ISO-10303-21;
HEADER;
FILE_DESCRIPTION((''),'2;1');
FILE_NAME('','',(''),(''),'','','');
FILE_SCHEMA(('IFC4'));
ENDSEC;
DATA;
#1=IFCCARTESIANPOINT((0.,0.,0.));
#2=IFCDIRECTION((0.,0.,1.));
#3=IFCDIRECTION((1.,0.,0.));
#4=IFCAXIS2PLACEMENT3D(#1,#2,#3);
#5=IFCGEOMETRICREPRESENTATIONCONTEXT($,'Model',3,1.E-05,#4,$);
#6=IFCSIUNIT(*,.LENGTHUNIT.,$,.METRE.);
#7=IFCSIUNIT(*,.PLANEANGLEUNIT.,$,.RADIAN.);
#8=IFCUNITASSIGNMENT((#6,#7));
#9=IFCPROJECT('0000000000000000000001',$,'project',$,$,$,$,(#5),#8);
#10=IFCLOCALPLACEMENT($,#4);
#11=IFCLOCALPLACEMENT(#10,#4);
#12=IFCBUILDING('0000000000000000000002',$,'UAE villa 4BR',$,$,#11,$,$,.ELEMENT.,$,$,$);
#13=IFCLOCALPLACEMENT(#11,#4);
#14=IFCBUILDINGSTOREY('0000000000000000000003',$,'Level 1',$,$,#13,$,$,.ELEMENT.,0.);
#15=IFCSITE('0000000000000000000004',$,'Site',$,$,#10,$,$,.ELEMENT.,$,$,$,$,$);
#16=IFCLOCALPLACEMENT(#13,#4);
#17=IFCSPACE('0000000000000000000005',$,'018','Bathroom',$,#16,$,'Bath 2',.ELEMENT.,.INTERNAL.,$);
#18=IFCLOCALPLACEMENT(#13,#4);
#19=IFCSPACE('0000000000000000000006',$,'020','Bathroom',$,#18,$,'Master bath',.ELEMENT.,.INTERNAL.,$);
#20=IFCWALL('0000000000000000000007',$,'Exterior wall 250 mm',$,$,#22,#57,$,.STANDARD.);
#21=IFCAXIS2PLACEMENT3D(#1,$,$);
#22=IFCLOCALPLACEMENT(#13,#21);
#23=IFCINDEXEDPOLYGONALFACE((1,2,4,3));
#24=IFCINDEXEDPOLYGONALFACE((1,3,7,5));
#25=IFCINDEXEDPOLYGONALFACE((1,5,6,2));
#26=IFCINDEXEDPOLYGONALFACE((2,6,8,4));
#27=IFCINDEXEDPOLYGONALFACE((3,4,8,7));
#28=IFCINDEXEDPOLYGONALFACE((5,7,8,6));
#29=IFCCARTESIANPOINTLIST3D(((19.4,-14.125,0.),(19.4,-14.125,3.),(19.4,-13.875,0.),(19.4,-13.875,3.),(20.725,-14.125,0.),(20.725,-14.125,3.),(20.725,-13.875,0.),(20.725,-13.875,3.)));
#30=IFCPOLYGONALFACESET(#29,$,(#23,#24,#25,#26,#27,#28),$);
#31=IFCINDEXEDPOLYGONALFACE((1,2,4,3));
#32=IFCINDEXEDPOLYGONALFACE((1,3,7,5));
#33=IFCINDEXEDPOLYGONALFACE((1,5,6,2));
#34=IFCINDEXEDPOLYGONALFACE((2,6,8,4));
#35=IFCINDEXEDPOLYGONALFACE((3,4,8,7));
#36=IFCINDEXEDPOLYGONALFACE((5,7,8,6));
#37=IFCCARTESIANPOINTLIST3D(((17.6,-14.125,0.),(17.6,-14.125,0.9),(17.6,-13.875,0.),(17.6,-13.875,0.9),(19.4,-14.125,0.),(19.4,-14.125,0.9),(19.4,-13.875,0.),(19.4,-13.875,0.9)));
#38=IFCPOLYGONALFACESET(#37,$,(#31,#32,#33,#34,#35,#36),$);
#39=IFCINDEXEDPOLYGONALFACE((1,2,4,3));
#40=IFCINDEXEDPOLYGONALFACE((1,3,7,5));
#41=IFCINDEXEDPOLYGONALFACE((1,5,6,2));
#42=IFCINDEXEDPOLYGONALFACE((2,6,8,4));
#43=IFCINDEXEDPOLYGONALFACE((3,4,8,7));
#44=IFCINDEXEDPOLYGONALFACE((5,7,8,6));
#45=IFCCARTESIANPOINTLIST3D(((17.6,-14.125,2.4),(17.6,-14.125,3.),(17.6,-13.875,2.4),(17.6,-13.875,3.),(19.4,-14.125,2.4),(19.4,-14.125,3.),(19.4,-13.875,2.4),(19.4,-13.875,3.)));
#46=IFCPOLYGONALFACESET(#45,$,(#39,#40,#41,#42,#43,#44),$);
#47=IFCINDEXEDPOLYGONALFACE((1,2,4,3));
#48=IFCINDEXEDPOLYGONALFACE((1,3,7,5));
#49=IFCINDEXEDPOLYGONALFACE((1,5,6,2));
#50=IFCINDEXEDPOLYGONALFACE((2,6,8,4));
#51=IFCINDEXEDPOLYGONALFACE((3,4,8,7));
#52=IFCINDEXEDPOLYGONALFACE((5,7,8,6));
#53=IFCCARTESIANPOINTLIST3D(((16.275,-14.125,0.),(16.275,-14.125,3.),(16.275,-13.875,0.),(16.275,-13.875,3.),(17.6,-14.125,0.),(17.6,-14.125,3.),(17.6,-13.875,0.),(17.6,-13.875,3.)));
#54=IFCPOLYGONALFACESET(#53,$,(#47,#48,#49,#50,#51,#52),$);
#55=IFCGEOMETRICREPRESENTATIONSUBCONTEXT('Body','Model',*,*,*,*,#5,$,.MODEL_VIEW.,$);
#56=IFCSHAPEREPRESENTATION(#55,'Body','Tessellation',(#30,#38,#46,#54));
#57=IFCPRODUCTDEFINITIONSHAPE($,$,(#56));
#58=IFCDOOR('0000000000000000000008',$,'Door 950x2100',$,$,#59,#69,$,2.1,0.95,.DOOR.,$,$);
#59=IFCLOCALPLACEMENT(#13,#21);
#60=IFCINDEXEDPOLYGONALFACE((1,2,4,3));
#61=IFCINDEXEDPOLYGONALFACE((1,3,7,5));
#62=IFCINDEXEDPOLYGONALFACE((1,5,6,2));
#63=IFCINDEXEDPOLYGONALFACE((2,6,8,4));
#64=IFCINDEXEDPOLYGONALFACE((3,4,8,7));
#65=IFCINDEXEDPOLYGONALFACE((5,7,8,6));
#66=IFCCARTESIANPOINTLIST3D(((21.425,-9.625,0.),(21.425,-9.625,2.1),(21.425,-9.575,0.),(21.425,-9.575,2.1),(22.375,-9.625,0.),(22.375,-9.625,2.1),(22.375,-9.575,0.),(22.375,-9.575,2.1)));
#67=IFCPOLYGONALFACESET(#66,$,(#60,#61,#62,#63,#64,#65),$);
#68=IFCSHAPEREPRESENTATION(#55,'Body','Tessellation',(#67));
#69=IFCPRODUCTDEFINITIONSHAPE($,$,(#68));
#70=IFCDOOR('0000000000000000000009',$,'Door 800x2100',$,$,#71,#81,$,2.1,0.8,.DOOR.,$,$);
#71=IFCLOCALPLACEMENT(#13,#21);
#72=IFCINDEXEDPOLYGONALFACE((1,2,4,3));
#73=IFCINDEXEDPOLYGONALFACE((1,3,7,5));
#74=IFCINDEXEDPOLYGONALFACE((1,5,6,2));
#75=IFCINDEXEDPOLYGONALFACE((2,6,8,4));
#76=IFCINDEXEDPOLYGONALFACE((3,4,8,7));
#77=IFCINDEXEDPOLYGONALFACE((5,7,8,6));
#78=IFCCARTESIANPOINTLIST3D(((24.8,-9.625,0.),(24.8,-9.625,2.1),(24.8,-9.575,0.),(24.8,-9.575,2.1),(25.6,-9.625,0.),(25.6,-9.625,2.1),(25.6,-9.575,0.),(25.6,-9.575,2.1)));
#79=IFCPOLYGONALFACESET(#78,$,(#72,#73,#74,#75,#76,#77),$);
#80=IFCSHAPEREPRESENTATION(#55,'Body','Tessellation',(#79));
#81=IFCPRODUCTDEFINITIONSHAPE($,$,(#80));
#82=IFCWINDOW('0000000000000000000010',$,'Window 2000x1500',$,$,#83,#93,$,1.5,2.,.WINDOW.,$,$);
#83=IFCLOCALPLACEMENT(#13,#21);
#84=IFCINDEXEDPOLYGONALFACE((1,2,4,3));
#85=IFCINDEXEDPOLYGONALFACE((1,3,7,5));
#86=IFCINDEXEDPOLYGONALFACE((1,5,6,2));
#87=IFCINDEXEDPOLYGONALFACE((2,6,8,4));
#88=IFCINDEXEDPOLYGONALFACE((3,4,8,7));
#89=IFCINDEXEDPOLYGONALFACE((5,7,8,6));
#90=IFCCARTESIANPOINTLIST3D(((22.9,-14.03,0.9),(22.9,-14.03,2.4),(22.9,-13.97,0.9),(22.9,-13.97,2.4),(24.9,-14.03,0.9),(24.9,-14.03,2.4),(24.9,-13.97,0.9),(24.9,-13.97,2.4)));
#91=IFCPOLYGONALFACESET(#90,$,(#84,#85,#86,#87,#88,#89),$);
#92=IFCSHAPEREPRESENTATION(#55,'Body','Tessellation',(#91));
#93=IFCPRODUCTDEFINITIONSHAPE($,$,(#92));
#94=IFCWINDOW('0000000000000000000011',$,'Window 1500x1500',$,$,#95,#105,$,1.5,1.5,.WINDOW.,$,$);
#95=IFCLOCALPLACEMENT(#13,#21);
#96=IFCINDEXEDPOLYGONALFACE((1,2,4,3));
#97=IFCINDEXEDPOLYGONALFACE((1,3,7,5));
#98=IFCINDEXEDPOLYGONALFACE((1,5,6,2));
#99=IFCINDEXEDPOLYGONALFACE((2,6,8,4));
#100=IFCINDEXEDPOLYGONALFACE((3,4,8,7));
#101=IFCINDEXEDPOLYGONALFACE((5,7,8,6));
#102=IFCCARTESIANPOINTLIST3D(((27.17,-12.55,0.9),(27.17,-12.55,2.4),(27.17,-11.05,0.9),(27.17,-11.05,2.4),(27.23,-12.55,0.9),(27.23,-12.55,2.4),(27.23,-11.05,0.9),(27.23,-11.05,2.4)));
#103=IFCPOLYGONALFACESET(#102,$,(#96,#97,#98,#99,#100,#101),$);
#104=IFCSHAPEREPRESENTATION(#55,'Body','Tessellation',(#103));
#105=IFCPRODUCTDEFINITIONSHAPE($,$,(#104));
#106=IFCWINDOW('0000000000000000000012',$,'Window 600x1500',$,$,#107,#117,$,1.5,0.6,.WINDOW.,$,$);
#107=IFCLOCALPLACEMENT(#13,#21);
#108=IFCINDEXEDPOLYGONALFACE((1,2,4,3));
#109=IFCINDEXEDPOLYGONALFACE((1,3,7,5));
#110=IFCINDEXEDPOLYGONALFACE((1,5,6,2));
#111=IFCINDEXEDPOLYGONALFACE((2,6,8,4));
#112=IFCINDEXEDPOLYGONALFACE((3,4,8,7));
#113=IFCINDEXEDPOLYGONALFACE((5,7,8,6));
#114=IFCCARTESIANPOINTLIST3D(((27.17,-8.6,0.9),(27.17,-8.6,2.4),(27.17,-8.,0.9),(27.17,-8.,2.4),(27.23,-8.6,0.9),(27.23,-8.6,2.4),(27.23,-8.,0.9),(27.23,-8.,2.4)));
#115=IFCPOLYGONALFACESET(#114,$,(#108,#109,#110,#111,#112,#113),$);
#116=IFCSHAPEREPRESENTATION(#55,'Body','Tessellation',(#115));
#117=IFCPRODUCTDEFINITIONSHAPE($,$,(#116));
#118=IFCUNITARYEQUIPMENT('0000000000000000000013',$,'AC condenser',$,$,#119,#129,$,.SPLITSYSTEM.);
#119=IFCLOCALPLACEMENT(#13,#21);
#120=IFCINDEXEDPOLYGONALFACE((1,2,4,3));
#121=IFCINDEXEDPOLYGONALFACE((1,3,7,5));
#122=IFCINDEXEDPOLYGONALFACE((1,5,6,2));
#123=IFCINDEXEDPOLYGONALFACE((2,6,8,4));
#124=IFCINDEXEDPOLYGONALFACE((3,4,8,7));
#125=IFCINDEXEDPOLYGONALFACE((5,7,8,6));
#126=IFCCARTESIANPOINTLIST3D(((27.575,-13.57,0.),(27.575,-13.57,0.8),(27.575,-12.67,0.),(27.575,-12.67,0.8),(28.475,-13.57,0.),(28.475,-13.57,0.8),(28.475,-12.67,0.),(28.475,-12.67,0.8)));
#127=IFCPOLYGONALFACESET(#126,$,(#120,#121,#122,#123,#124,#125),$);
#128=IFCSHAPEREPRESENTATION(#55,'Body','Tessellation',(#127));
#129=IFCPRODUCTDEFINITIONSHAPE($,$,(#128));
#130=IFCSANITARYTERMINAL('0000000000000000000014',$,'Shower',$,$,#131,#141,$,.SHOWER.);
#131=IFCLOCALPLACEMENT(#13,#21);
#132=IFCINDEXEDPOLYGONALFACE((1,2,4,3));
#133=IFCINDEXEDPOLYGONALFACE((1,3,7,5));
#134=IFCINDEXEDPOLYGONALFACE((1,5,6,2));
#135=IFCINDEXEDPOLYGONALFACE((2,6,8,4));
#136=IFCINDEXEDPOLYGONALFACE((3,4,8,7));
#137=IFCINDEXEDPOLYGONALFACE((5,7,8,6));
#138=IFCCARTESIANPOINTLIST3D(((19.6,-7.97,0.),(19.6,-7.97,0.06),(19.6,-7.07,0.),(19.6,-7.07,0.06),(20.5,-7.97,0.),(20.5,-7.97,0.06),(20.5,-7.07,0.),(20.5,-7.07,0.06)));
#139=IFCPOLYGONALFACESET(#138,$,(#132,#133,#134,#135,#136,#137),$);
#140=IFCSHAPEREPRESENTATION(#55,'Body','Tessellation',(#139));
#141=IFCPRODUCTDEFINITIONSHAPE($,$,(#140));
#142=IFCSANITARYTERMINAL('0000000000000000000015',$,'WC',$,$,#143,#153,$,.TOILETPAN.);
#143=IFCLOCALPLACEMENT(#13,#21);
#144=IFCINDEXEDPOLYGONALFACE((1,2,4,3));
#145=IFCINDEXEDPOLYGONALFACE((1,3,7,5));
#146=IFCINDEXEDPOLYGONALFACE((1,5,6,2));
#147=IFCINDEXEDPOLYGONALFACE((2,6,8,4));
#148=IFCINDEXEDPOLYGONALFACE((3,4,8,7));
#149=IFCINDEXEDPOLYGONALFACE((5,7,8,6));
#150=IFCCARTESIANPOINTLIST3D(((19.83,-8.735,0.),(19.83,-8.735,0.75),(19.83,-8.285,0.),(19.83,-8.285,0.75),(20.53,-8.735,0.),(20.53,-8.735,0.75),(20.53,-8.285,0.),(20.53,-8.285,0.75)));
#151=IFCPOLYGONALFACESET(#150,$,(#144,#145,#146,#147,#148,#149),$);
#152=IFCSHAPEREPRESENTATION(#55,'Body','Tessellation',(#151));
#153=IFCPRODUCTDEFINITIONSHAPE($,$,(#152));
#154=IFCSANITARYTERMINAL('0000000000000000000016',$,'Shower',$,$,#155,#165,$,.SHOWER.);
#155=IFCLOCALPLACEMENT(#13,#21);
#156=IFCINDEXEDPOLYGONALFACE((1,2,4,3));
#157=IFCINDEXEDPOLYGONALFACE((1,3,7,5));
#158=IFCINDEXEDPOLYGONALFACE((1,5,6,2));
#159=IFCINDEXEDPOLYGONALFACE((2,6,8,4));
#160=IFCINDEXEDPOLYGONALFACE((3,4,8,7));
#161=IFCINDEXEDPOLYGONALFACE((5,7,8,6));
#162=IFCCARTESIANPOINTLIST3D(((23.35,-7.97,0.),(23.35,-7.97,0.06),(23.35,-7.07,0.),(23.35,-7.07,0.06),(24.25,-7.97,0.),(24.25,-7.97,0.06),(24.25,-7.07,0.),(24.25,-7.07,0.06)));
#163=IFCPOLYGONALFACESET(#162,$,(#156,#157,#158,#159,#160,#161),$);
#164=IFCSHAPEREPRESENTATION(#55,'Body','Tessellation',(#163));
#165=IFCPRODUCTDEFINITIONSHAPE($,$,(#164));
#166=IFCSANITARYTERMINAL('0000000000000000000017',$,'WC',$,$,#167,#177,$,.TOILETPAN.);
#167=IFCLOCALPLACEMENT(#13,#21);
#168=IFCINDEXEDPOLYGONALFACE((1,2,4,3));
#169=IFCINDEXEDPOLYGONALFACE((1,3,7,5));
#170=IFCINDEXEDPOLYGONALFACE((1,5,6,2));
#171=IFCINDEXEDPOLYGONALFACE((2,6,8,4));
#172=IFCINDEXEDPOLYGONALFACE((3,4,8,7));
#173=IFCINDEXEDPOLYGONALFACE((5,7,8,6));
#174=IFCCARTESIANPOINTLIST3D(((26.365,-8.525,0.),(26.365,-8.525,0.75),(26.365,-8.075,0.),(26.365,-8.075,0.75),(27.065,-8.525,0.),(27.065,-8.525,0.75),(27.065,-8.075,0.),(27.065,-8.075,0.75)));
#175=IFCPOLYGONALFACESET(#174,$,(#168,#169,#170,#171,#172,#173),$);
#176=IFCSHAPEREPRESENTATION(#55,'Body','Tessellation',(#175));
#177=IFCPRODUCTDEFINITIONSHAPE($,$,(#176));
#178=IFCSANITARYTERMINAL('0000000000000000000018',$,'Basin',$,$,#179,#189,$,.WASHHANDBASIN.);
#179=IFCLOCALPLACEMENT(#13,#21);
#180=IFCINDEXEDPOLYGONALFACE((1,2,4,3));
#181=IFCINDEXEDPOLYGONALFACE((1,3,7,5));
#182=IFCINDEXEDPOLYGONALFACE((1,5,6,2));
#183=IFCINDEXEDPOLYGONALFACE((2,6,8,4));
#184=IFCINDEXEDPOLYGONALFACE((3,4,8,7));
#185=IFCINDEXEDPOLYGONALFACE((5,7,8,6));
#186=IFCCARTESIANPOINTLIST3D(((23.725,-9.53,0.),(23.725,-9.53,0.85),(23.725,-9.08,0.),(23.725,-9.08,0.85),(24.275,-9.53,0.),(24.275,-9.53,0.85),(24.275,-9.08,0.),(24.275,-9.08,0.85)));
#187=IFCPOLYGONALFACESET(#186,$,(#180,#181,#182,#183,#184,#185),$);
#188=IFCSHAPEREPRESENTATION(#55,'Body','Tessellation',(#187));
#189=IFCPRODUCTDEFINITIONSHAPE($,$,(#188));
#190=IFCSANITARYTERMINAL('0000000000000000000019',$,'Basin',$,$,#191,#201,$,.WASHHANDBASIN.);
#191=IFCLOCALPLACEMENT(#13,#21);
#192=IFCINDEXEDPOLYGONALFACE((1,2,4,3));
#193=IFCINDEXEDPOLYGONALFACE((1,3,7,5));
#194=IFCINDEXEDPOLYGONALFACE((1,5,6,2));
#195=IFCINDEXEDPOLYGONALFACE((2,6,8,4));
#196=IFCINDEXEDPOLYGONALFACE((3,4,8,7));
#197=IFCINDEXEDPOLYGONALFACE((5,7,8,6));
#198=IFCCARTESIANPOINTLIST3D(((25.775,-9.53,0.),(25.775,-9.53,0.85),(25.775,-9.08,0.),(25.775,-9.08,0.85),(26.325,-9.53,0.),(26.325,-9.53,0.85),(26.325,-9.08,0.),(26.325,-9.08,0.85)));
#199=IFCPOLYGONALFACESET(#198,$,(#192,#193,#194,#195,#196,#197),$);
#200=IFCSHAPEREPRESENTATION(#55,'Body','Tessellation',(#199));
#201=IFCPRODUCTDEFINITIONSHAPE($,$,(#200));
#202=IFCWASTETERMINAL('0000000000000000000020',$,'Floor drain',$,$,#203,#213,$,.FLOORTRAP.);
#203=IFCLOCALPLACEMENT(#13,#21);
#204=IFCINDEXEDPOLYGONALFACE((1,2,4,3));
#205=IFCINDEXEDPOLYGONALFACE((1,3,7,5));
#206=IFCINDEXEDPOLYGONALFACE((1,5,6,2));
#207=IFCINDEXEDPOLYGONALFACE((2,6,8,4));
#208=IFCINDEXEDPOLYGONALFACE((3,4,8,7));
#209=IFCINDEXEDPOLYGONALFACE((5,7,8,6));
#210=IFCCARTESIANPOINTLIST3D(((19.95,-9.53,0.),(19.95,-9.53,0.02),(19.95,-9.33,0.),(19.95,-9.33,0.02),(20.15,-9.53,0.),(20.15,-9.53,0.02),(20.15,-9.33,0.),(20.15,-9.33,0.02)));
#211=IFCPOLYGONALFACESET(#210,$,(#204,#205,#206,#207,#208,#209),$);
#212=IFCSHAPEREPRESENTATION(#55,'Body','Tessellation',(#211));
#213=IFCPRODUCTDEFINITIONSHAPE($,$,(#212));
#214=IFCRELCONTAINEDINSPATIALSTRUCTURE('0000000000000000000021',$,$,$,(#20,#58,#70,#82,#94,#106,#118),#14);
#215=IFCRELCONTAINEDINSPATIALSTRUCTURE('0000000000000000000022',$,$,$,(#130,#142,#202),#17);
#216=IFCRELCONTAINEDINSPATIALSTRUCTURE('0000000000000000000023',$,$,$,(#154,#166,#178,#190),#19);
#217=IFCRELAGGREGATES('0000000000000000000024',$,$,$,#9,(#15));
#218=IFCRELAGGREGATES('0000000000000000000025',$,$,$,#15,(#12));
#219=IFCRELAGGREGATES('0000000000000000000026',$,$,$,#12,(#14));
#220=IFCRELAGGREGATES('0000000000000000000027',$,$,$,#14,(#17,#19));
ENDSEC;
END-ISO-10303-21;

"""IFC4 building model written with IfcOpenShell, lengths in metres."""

from ifc_helpers import new_model, si_unit, frame, origin, origin_with_axes, origin_2d, place, context, subcontext, project, spatial, rectangle, extrude, element, save


model = new_model("IFC4")

# Units and contexts
model_context = context("Model", 3, precision=1e-05, world=origin_with_axes())
body_context = subcontext(model_context, "Body", "Model", "MODEL_VIEW")
ifc_project = project(units=[si_unit("LENGTHUNIT", "METRE"), si_unit("PLANEANGLEUNIT", "RADIAN")], contexts=[model_context])

# Site, building, storey
site_placement = place(None, origin_with_axes())
site = spatial("IfcSite", under=ifc_project, at=site_placement, Name="Site", CompositionType="ELEMENT")
building_placement = place(site_placement, origin_with_axes())
building = spatial("IfcBuilding", under=site, at=building_placement, Name="UAE villa 4BR", CompositionType="ELEMENT")
storey_placement = place(building_placement, origin_with_axes())
storey = spatial("IfcBuildingStorey", under=building, at=storey_placement, Name="Level 1", CompositionType="ELEMENT", Elevation=0.0)

# Wall
wall_1_placement = place(storey_placement, frame((20.6, -14.0, 0.0), z_axis=(0.0, 0.0, 1.0), x_axis=(-1.0, 0.0, 0.0)))
element("IfcWall", 1, at=wall_1_placement, inside=storey, Name="Exterior wall 250 mm", PredefinedType="STANDARD", context=body_context, shape_type="SweptSolid", body=[
    extrude(rectangle(XDim=1.325, YDim=0.25, at=origin_2d()), frame((0.5375, 0.0, 0.0)), (0.0, 0.0, 1.0), 3.0),
    extrude(rectangle(XDim=1.8, YDim=0.25, at=origin_2d()), frame((2.1, 0.0, 0.0)), (0.0, 0.0, 1.0), 0.9),
    extrude(rectangle(XDim=1.8, YDim=0.25, at=origin_2d()), frame((2.1, 0.0, 2.4)), (0.0, 0.0, 1.0), 0.6),
    extrude(rectangle(XDim=1.325, YDim=0.25, at=origin_2d()), frame((3.6625, 0.0, 0.0)), (0.0, 0.0, 1.0), 3.0),
])

# Doors
door_1_placement = place(storey_placement, frame((21.9, -9.6, 0.0), z_axis=(0.0, 0.0, 1.0), x_axis=(-1.0, 0.0, 0.0)))
element("IfcDoor", 2, at=door_1_placement, inside=storey, Name="Door 950x2100", OverallHeight=2.1, OverallWidth=0.95, PredefinedType="DOOR", context=body_context, shape_type="SweptSolid", body=[
    extrude(rectangle(XDim=0.95, YDim=0.05, at=origin_2d()), origin(), (0.0, 0.0, 1.0), 2.1),
])
door_2_placement = place(storey_placement, frame((25.2, -9.6, 0.0), z_axis=(0.0, 0.0, 1.0), x_axis=(-1.0, 0.0, 0.0)))
element("IfcDoor", 3, at=door_2_placement, inside=storey, Name="Door 800x2100", OverallHeight=2.1, OverallWidth=0.8, PredefinedType="DOOR", context=body_context, shape_type="SweptSolid", body=[
    extrude(rectangle(XDim=0.8, YDim=0.05, at=origin_2d()), origin(), (0.0, 0.0, 1.0), 2.1),
])

# Windows
window_1_placement = place(storey_placement, frame((23.9, -14.0, 0.9), z_axis=(0.0, 0.0, 1.0), x_axis=(-1.0, 0.0, 0.0)))
element("IfcWindow", 4, at=window_1_placement, inside=storey, Name="Window 2000x1500", OverallHeight=1.5, OverallWidth=2.0, PredefinedType="WINDOW", context=body_context, shape_type="SweptSolid", body=[
    extrude(rectangle(XDim=2.0, YDim=0.06, at=origin_2d()), origin(), (0.0, 0.0, 1.0), 1.5),
])
window_2_placement = place(storey_placement, frame((27.2, -11.8, 0.9), z_axis=(0.0, 0.0, 1.0), x_axis=(0.0, -1.0, 0.0)))
element("IfcWindow", 5, at=window_2_placement, inside=storey, Name="Window 1500x1500", OverallHeight=1.5, OverallWidth=1.5, PredefinedType="WINDOW", context=body_context, shape_type="SweptSolid", body=[
    extrude(rectangle(XDim=1.5, YDim=0.06, at=origin_2d()), origin(), (0.0, 0.0, 1.0), 1.5),
])
window_3_placement = place(storey_placement, frame((27.2, -8.3, 0.9), z_axis=(0.0, 0.0, 1.0), x_axis=(0.0, -1.0, 0.0)))
element("IfcWindow", 6, at=window_3_placement, inside=storey, Name="Window 600x1500", OverallHeight=1.5, OverallWidth=0.6, PredefinedType="WINDOW", context=body_context, shape_type="SweptSolid", body=[
    extrude(rectangle(XDim=0.6, YDim=0.06, at=origin_2d()), origin(), (0.0, 0.0, 1.0), 1.5),
])

# Unitary equipment
unitary_equipment_placement = place(storey_placement, frame((28.025, -13.12, 0.0), z_axis=(0.0, 0.0, 1.0), x_axis=(0.0, 1.0, 0.0)))
element("IfcUnitaryEquipment", 7, at=unitary_equipment_placement, inside=storey, Name="AC condenser", PredefinedType="SPLITSYSTEM", context=body_context, shape_type="SweptSolid", body=[
    extrude(rectangle(XDim=0.9, YDim=0.9, at=origin_2d()), origin(), (0.0, 0.0, 1.0), 0.8),
])

# Shared definitions
space_1_placement = place(storey_placement, origin_with_axes())
space_1 = spatial("IfcSpace", under=storey, at=space_1_placement, Name="018", Description="Bathroom", LongName="Bath 2", CompositionType="ELEMENT", PredefinedType="INTERNAL")

# Sanitary terminals
sanitary_terminal_1_placement = place(storey_placement, frame((20.05, -7.52, 0.0), z_axis=(0.0, 0.0, 1.0), x_axis=(1.0, 0.0, 0.0)))
element("IfcSanitaryTerminal", 8, at=sanitary_terminal_1_placement, inside=space_1, Name="Shower", PredefinedType="SHOWER", context=body_context, shape_type="SweptSolid", body=[
    extrude(rectangle(XDim=0.9, YDim=0.9, at=origin_2d()), origin(), (0.0, 0.0, 1.0), 0.06),
])
sanitary_terminal_2_placement = place(storey_placement, frame((20.18, -8.51, 0.0), z_axis=(0.0, 0.0, 1.0), x_axis=(0.0, -1.0, 0.0)))
element("IfcSanitaryTerminal", 9, at=sanitary_terminal_2_placement, inside=space_1, Name="WC", PredefinedType="TOILETPAN", context=body_context, shape_type="SweptSolid", body=[
    extrude(rectangle(XDim=0.45, YDim=0.7, at=origin_2d()), origin(), (0.0, 0.0, 1.0), 0.75),
])

# Shared definitions
space_2_placement = place(storey_placement, origin_with_axes())
space_2 = spatial("IfcSpace", under=storey, at=space_2_placement, Name="020", Description="Bathroom", LongName="Master bath", CompositionType="ELEMENT", PredefinedType="INTERNAL")

# Sanitary terminals
sanitary_terminal_3_placement = place(storey_placement, frame((23.8, -7.52, 0.0), z_axis=(0.0, 0.0, 1.0), x_axis=(1.0, 0.0, 0.0)))
element("IfcSanitaryTerminal", 10, at=sanitary_terminal_3_placement, inside=space_2, Name="Shower", PredefinedType="SHOWER", context=body_context, shape_type="SweptSolid", body=[
    extrude(rectangle(XDim=0.9, YDim=0.9, at=origin_2d()), origin(), (0.0, 0.0, 1.0), 0.06),
])
sanitary_terminal_4_placement = place(storey_placement, frame((26.715, -8.3, 0.0), z_axis=(0.0, 0.0, 1.0), x_axis=(0.0, -1.0, 0.0)))
element("IfcSanitaryTerminal", 11, at=sanitary_terminal_4_placement, inside=space_2, Name="WC", PredefinedType="TOILETPAN", context=body_context, shape_type="SweptSolid", body=[
    extrude(rectangle(XDim=0.45, YDim=0.7, at=origin_2d()), origin(), (0.0, 0.0, 1.0), 0.75),
])
for number, where, z_axis, x_axis, name in (
    (12, (24.0, -9.305, 0.0), (0.0, 0.0, 1.0), (-1.0, 0.0, 0.0), "Basin"),
    (13, (26.05, -9.305, 0.0), (0.0, 0.0, 1.0), (-1.0, 0.0, 0.0), "Basin"),
):
    element("IfcSanitaryTerminal", number, at=place(storey_placement, frame(where, z_axis=z_axis, x_axis=x_axis)), inside=space_2, Name=name, PredefinedType="WASHHANDBASIN", context=body_context, shape_type="SweptSolid", body=[
        extrude(rectangle(XDim=0.55, YDim=0.45, at=origin_2d()), origin(), (0.0, 0.0, 1.0), 0.85),
    ])

# Waste terminal
waste_terminal_1_placement = place(storey_placement, frame((20.05, -9.43, 0.0), z_axis=(0.0, 0.0, 1.0), x_axis=(-1.0, 0.0, 0.0)))
element("IfcWasteTerminal", 14, at=waste_terminal_1_placement, inside=space_1, Name="Floor drain", PredefinedType="FLOORTRAP", context=body_context, shape_type="SweptSolid", body=[
    extrude(rectangle(XDim=0.2, YDim=0.2, at=origin_2d()), origin(), (0.0, 0.0, 1.0), 0.02),
])

save(model, "model.ifc")
